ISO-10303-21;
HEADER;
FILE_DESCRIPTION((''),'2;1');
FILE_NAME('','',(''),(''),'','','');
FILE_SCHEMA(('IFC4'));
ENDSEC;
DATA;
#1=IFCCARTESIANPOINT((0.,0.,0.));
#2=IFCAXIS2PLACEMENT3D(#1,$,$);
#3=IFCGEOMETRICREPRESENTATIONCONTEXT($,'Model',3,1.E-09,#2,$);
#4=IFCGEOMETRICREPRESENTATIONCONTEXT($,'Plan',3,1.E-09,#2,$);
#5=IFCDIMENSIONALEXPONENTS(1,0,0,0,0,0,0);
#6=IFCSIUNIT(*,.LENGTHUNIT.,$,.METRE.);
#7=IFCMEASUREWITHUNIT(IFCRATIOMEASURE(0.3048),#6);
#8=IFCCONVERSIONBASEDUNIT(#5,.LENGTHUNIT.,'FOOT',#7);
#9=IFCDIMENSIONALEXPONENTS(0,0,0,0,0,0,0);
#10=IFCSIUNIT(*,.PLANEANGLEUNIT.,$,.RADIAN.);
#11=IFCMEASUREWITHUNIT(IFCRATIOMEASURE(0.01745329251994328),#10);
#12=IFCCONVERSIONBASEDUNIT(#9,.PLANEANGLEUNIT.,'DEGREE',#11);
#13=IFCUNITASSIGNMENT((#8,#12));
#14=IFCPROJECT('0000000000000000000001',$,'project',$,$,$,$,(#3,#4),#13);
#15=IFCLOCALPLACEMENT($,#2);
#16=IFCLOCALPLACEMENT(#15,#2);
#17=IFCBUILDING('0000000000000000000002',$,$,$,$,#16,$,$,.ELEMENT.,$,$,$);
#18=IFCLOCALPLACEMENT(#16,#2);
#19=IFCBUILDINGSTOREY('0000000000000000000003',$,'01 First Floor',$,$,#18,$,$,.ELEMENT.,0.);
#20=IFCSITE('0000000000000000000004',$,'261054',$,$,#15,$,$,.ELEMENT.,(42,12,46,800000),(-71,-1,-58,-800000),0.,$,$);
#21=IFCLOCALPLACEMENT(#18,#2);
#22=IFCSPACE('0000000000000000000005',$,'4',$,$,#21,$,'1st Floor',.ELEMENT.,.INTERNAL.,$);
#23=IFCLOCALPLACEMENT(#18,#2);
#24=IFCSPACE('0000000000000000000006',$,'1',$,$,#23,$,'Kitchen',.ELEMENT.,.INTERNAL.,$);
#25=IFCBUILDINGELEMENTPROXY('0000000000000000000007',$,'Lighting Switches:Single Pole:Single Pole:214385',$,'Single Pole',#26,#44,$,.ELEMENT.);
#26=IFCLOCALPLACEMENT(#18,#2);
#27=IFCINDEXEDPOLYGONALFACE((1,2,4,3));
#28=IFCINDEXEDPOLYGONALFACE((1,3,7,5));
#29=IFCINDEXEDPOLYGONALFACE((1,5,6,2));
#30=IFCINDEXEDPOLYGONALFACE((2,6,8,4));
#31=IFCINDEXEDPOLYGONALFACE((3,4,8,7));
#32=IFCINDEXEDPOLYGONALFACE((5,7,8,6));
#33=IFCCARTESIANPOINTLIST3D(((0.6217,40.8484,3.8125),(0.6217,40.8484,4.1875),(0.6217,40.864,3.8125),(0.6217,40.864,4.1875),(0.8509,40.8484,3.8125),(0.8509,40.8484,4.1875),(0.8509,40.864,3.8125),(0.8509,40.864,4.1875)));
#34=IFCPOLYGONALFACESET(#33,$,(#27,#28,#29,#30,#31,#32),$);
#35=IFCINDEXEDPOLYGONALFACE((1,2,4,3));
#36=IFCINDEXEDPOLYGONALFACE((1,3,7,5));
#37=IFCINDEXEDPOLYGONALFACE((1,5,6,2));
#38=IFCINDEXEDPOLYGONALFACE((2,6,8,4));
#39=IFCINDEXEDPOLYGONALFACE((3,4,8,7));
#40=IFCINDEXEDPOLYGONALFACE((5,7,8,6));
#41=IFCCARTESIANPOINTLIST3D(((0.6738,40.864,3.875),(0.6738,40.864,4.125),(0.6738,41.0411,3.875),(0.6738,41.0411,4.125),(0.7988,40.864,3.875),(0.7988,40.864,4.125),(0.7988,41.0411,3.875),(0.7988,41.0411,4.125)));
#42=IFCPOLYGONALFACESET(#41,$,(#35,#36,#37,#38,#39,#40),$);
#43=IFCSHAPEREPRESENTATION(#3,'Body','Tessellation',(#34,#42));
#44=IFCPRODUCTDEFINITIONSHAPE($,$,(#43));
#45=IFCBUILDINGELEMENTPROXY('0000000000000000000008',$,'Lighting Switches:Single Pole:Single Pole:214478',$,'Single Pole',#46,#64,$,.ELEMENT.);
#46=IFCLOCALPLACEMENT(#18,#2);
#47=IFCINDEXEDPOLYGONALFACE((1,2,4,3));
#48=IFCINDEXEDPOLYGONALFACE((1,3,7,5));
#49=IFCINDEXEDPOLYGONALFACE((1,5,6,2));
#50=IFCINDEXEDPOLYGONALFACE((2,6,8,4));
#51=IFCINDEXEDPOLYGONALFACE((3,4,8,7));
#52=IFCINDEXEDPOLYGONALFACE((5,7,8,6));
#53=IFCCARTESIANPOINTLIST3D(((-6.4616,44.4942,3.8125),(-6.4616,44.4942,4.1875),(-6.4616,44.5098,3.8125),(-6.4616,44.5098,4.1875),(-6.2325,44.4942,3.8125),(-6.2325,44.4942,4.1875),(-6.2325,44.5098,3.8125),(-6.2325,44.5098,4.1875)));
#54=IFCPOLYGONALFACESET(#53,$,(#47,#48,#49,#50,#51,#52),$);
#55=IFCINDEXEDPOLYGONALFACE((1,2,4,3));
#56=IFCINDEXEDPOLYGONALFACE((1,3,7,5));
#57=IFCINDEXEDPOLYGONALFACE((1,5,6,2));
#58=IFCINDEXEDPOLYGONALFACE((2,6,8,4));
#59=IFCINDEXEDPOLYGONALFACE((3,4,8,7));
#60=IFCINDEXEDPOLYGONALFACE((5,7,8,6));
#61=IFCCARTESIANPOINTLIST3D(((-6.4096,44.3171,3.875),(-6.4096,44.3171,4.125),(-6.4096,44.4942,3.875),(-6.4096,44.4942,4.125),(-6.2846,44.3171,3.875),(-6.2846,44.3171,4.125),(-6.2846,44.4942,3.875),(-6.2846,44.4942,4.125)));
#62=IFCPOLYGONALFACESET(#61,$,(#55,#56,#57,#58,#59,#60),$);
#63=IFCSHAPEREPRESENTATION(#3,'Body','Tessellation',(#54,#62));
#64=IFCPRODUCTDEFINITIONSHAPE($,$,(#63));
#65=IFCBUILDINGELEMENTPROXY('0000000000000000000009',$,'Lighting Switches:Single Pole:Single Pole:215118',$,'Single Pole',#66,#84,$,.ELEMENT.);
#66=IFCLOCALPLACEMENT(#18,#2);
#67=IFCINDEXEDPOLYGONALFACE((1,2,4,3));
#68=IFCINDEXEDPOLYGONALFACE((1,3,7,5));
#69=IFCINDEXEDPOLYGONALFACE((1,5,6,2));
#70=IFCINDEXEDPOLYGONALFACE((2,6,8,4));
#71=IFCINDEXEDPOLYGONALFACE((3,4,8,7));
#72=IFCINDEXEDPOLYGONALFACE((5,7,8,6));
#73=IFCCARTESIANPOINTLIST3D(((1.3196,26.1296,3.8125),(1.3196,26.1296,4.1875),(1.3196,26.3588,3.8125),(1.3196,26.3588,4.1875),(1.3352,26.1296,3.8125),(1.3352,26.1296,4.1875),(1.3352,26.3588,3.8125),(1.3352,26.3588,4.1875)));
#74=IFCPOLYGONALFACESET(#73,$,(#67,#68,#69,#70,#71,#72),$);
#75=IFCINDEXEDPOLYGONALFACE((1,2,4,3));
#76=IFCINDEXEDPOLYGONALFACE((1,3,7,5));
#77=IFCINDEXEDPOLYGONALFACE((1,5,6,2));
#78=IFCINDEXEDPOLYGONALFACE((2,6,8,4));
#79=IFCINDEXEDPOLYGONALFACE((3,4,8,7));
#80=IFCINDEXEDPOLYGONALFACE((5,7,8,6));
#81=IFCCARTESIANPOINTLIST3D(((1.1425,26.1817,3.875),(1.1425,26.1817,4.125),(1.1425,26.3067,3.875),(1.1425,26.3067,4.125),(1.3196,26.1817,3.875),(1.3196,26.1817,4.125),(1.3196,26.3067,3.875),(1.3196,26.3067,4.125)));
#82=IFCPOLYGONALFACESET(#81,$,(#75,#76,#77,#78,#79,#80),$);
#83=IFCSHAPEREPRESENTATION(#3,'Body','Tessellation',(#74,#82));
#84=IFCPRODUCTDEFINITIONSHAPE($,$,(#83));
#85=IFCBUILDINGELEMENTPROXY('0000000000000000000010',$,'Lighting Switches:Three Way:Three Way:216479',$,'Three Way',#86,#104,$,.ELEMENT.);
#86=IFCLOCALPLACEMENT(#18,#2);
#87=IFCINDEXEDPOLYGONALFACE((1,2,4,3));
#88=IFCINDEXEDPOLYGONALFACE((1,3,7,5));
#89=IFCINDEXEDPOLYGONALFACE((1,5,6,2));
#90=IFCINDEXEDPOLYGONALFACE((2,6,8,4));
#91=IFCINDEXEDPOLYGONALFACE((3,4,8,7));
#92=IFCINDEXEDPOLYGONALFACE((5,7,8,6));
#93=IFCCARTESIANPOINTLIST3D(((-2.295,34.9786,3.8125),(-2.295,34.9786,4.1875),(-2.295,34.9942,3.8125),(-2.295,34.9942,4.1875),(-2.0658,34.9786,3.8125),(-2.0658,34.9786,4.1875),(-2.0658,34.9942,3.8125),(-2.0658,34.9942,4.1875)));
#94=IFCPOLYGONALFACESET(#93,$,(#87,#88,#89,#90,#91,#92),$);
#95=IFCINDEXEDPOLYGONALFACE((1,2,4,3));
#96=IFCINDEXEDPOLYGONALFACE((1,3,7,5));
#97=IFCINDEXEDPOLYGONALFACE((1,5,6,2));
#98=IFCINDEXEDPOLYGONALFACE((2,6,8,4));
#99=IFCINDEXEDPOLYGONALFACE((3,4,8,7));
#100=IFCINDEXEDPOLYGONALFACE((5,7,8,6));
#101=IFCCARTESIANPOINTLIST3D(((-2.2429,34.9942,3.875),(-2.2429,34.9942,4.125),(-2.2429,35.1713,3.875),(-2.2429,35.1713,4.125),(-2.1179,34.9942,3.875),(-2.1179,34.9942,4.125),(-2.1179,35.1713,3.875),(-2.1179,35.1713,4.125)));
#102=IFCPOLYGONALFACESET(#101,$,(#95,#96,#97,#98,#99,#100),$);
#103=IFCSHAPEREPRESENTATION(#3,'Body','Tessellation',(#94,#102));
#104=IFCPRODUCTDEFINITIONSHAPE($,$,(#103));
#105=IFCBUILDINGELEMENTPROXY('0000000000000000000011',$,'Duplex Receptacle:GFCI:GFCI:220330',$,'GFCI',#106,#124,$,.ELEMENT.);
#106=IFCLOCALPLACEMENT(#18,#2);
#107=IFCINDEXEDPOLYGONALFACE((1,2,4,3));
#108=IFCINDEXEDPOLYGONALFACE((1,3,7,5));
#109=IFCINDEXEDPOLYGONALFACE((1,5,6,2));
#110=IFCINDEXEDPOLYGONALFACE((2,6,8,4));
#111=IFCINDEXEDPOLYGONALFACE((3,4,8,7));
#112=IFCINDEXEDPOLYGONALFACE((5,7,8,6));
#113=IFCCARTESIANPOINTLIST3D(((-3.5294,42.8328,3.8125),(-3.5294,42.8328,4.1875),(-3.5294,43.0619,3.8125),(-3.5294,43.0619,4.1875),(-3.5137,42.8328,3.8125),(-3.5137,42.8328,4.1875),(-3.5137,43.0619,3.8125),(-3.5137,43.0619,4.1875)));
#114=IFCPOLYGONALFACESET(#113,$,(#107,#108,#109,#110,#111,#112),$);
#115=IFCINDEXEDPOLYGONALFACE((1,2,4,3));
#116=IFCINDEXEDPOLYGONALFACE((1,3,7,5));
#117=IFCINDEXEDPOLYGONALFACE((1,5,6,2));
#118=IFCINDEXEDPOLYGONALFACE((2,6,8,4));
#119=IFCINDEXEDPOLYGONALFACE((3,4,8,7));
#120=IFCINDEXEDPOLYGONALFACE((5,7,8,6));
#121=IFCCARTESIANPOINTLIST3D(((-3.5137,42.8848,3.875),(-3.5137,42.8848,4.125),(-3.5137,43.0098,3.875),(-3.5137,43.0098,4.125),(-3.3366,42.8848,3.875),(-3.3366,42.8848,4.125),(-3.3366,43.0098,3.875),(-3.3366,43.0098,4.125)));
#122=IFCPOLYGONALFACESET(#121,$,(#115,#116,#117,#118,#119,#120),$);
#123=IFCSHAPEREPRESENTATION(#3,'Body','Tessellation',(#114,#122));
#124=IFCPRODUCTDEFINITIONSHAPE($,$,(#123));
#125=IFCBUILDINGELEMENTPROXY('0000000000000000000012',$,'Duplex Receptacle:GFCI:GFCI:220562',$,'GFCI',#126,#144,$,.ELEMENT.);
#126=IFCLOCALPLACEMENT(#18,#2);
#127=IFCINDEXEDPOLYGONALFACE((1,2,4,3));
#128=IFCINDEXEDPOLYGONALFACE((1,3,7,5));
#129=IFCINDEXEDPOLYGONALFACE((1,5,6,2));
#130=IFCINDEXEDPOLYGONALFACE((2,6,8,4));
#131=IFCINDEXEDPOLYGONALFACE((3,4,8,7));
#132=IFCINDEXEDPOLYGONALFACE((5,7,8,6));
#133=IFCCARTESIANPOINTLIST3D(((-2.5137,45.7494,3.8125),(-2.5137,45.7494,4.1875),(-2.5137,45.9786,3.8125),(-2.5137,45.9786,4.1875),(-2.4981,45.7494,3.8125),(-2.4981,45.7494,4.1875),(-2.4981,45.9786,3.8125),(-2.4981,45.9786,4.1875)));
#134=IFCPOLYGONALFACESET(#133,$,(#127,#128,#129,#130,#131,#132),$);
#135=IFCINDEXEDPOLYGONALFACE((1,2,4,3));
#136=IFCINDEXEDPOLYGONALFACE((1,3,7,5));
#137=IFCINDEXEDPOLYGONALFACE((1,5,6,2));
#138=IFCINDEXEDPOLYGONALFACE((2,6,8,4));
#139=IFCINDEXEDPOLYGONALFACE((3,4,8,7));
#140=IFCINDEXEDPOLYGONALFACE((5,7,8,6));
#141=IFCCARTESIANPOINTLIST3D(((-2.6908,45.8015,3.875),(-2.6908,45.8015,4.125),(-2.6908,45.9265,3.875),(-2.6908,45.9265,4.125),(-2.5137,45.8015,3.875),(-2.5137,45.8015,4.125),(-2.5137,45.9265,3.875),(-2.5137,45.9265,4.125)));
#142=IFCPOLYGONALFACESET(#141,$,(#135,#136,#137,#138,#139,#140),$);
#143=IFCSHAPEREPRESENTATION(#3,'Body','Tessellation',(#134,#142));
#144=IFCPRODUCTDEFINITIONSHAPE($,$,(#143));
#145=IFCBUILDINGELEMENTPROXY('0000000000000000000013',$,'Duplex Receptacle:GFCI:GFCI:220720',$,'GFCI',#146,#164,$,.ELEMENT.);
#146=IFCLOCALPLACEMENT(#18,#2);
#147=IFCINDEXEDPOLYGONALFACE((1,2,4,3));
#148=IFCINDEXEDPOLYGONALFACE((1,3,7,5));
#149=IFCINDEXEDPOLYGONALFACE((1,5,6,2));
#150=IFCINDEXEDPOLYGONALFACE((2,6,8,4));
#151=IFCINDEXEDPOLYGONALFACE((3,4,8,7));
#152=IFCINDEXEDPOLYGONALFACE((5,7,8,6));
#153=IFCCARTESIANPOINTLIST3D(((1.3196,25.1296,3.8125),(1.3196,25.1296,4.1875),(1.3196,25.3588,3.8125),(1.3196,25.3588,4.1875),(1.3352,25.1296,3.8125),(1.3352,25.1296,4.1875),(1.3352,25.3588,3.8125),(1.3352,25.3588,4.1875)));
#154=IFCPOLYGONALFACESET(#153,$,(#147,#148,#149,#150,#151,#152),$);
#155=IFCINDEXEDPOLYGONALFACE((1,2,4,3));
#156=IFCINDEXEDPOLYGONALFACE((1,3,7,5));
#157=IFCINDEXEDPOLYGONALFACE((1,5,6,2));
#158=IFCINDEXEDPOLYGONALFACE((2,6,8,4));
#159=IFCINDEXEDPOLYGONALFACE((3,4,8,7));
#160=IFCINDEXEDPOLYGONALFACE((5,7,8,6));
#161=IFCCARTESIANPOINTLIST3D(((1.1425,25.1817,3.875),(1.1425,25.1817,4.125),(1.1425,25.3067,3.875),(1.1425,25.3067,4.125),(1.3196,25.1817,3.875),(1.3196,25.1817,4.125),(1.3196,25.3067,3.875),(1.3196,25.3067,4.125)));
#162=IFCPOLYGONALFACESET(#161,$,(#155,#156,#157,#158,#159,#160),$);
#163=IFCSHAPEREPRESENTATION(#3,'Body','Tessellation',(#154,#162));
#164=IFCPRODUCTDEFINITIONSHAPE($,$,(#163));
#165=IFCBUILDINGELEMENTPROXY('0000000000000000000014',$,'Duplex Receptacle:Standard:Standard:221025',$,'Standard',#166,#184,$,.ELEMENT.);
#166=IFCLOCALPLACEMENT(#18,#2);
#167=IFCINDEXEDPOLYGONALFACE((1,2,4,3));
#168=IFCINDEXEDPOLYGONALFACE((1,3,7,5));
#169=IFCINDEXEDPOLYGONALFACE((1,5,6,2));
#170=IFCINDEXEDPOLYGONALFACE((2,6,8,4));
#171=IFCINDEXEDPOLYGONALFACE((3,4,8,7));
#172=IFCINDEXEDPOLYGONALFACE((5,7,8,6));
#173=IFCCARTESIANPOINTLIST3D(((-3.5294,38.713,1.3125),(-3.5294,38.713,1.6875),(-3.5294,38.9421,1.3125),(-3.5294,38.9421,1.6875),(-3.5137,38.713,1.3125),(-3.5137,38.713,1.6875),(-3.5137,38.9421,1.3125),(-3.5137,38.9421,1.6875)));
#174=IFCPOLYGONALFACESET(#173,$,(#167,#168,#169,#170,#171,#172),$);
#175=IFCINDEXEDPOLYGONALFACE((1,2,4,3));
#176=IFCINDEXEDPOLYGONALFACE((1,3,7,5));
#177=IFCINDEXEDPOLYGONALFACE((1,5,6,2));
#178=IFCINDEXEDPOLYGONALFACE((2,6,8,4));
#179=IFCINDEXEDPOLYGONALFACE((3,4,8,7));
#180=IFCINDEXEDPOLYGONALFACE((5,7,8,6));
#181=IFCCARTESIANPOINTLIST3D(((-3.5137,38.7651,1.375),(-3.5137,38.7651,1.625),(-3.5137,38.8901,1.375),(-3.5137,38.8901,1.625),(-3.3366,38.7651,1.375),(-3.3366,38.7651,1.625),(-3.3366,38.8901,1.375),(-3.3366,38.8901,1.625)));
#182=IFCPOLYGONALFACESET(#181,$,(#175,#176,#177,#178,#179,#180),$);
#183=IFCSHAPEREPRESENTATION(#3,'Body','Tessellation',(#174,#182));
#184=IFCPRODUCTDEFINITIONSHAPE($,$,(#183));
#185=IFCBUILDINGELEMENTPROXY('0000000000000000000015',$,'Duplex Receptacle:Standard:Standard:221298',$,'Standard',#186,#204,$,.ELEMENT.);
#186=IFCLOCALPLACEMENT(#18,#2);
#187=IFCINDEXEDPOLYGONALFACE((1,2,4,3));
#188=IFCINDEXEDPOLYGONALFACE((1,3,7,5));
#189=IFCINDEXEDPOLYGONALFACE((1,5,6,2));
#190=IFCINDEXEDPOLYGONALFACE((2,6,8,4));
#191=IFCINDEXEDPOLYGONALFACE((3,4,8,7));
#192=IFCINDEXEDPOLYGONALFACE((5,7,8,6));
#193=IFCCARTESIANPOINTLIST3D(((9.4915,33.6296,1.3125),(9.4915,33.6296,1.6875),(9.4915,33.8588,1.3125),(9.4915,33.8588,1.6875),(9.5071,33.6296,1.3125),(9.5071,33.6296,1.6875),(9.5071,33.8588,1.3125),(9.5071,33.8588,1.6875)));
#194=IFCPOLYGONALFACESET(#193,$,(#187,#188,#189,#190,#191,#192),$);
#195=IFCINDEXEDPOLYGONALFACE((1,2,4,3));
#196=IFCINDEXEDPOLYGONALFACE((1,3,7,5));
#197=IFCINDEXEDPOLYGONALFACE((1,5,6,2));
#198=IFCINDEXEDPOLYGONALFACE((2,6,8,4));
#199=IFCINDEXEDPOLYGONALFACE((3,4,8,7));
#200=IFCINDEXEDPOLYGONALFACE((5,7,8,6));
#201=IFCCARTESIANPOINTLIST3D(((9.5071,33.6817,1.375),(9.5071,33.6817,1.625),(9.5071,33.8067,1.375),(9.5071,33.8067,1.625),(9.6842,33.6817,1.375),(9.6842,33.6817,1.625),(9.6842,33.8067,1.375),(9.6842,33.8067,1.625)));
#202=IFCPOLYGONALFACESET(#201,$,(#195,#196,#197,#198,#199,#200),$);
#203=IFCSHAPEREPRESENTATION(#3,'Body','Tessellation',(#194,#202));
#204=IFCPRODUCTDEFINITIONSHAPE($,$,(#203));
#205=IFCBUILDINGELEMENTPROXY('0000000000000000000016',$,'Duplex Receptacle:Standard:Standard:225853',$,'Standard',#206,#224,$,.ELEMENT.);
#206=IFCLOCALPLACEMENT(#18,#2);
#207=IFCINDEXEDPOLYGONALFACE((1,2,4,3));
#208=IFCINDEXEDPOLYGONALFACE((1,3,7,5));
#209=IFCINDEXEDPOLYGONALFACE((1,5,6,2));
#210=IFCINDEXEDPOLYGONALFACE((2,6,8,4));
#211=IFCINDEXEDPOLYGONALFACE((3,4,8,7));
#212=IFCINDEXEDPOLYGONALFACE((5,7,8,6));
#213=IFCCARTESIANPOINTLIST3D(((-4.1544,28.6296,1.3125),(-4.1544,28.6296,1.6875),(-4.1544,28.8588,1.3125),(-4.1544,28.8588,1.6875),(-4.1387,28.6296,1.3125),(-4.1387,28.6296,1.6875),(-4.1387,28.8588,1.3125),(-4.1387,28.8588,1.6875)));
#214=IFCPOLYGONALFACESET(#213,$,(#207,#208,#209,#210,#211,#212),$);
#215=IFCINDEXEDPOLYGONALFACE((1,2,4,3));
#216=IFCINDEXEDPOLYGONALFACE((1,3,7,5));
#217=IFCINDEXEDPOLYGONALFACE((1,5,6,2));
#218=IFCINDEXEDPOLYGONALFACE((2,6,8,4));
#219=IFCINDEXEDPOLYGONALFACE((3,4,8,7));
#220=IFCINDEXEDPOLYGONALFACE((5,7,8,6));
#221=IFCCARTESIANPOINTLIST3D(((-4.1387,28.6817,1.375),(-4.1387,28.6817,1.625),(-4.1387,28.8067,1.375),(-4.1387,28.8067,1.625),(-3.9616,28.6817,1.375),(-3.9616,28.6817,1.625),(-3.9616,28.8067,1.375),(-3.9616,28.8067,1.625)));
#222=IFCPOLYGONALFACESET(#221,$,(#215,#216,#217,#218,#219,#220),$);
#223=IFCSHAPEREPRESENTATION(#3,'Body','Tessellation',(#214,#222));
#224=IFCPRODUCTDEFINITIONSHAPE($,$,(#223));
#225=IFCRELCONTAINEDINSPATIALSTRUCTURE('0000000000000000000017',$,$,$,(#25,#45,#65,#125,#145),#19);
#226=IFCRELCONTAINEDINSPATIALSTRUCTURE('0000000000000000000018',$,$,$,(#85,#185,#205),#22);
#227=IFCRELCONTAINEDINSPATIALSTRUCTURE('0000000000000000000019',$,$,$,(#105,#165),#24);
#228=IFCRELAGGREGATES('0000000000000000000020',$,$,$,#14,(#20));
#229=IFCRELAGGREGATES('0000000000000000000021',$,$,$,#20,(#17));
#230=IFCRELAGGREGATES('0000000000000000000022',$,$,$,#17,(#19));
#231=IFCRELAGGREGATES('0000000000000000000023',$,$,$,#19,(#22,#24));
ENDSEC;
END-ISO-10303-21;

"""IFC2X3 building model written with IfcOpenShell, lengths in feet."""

from ifc_helpers import new_model, entity, si_unit, converted_unit, frame, origin, origin_2d_with_axis, place, context, project, spatial, rectangle, extrude, source, transform, mapped, element, save


model = new_model("IFC2X3")

# Units and contexts
model_context = context("Model", 3, precision=1e-09, world=origin())
plan_context = context("Plan", 3, precision=1e-09, world=origin())
ifc_project = project(units=[converted_unit("LENGTHUNIT", "FOOT", entity("IfcRatioMeasure", 0.3048), si_unit("LENGTHUNIT", "METRE"), dimensions=[1, 0, 0, 0, 0, 0, 0]), converted_unit("PLANEANGLEUNIT", "DEGREE", entity("IfcRatioMeasure", 0.01745329251994328), si_unit("PLANEANGLEUNIT", "RADIAN"), dimensions=[0, 0, 0, 0, 0, 0, 0])], contexts=[model_context, plan_context])

# Site, building, storey
site_placement = place(None, origin())
site = spatial("IfcSite", under=ifc_project, at=site_placement, Name="261054", CompositionType="ELEMENT", RefLatitude=(42, 12, 46, 800000), RefLongitude=(-71, -1, -58, -800000), RefElevation=0.0)
building_placement = place(site_placement, origin())
building = spatial("IfcBuilding", under=site, at=building_placement, CompositionType="ELEMENT")
storey_placement = place(building_placement, origin())
storey = spatial("IfcBuildingStorey", under=building, at=storey_placement, Name="01 First Floor", CompositionType="ELEMENT", Elevation=0.0)

# Building element proxies
shared_shape_1 = source(origin(), model_context, "Body", "SweptSolid", [
    extrude(rectangle(XDim=0.2292, YDim=0.375, at=origin_2d_with_axis()), frame((0.0, 0.0, 0.0), z_axis=(0.0, 0.0, 1.0), x_axis=(-1.0, 0.0, 0.0)), (0.0, 0.0, 1.0), 0.0156),
    extrude(rectangle(XDim=0.125, YDim=0.25, at=origin_2d_with_axis()), frame((0.0, 0.0, -0.1771), z_axis=(0.0, 0.0, 1.0), x_axis=(-1.0, 0.0, 0.0)), (0.0, 0.0, 1.0), 0.1771),
])
for number, where, z_axis, x_axis, name in (
    (1, (0.7363, 40.864, 4.0), (0.0, -1.0, 0.0), (1.0, 0.0, 0.0), "Lighting Switches:Single Pole:Single Pole:214385"),
    (2, (-6.3471, 44.4942, 4.0), (0.0, 1.0, 0.0), (-1.0, 0.0, 0.0), "Lighting Switches:Single Pole:Single Pole:214478"),
    (3, (1.3196, 26.2442, 4.0), (1.0, 0.0, 0.0), (0.0, 1.0, 0.0), "Lighting Switches:Single Pole:Single Pole:215118"),
):
    element("IfcBuildingElementProxy", number, at=place(storey_placement, frame(where, z_axis=z_axis, x_axis=x_axis)), inside=storey, Name=name, ObjectType="Single Pole", CompositionType="ELEMENT", context=model_context, shape_type="MappedRepresentation", body=[
        mapped(shared_shape_1, transform((0.0, 0.0, 0.0), scale=1.0)),
    ])

# Shared definitions
space_1_placement = place(storey_placement, origin())
space_1 = spatial("IfcSpace", under=storey, at=space_1_placement, Name="4", LongName="1st Floor", CompositionType="ELEMENT", InteriorOrExteriorSpace="INTERNAL")

# Building element proxy
shared_shape_2 = source(origin(), model_context, "Body", "SweptSolid", [
    extrude(rectangle(XDim=0.2292, YDim=0.375, at=origin_2d_with_axis()), frame((0.0, 0.0, 0.0), z_axis=(0.0, 0.0, 1.0), x_axis=(-1.0, 0.0, 0.0)), (0.0, 0.0, 1.0), 0.0156),
    extrude(rectangle(XDim=0.125, YDim=0.25, at=origin_2d_with_axis()), frame((0.0, 0.0, -0.1771), z_axis=(0.0, 0.0, 1.0), x_axis=(-1.0, 0.0, 0.0)), (0.0, 0.0, 1.0), 0.1771),
])
proxy_1_placement = place(space_1_placement, frame((-2.1804, 34.9942, 4.0), z_axis=(0.0, -1.0, 0.0), x_axis=(1.0, 0.0, 0.0)))
element("IfcBuildingElementProxy", 4, at=proxy_1_placement, inside=space_1, Name="Lighting Switches:Three Way:Three Way:216479", ObjectType="Three Way", CompositionType="ELEMENT", context=model_context, shape_type="MappedRepresentation", body=[
    mapped(shared_shape_2, transform((0.0, 0.0, 0.0), scale=1.0)),
])

# Shared definitions
space_2_placement = place(storey_placement, origin())
space_2 = spatial("IfcSpace", under=storey, at=space_2_placement, Name="1", LongName="Kitchen", CompositionType="ELEMENT", InteriorOrExteriorSpace="INTERNAL")

# Building element proxies
shared_shape_3 = source(origin(), model_context, "Body", "SweptSolid", [
    extrude(rectangle(XDim=0.2292, YDim=0.375, at=origin_2d_with_axis()), frame((0.0, 0.0, 0.0), z_axis=(0.0, 0.0, 1.0), x_axis=(-1.0, 0.0, 0.0)), (0.0, 0.0, 1.0), 0.0156),
    extrude(rectangle(XDim=0.125, YDim=0.25, at=origin_2d_with_axis()), frame((0.0, 0.0, -0.1771), z_axis=(0.0, 0.0, 1.0), x_axis=(-1.0, 0.0, 0.0)), (0.0, 0.0, 1.0), 0.1771),
])
proxy_2_placement = place(space_2_placement, frame((-3.5137, 42.9473, 4.0), z_axis=(-1.0, 0.0, 0.0), x_axis=(0.0, -1.0, 0.0)))
element("IfcBuildingElementProxy", 5, at=proxy_2_placement, inside=space_2, Name="Duplex Receptacle:GFCI:GFCI:220330", ObjectType="GFCI", CompositionType="ELEMENT", context=model_context, shape_type="MappedRepresentation", body=[
    mapped(shared_shape_3, transform((0.0, 0.0, 0.0), scale=1.0)),
])
for number, where, z_axis, x_axis, name in (
    (6, (-2.5137, 45.864, 4.0), (1.0, 0.0, 0.0), (0.0, 1.0, 0.0), "Duplex Receptacle:GFCI:GFCI:220562"),
    (7, (1.3196, 25.2442, 4.0), (1.0, 0.0, 0.0), (0.0, 1.0, 0.0), "Duplex Receptacle:GFCI:GFCI:220720"),
):
    element("IfcBuildingElementProxy", number, at=place(storey_placement, frame(where, z_axis=z_axis, x_axis=x_axis)), inside=storey, Name=name, ObjectType="GFCI", CompositionType="ELEMENT", context=model_context, shape_type="MappedRepresentation", body=[
        mapped(shared_shape_3, transform((0.0, 0.0, 0.0), scale=1.0)),
    ])
shared_shape_4 = source(origin(), model_context, "Body", "SweptSolid", [
    extrude(rectangle(XDim=0.2292, YDim=0.375, at=origin_2d_with_axis()), frame((0.0, 0.0, 0.0), z_axis=(0.0, 0.0, 1.0), x_axis=(-1.0, 0.0, 0.0)), (0.0, 0.0, 1.0), 0.0156),
    extrude(rectangle(XDim=0.125, YDim=0.25, at=origin_2d_with_axis()), frame((0.0, 0.0, -0.1771), z_axis=(0.0, 0.0, 1.0), x_axis=(-1.0, 0.0, 0.0)), (0.0, 0.0, 1.0), 0.1771),
])
proxy_3_placement = place(space_2_placement, frame((-3.5137, 38.8276, 1.5), z_axis=(-1.0, 0.0, 0.0), x_axis=(0.0, -1.0, 0.0)))
element("IfcBuildingElementProxy", 8, at=proxy_3_placement, inside=space_2, Name="Duplex Receptacle:Standard:Standard:221025", ObjectType="Standard", CompositionType="ELEMENT", context=model_context, shape_type="MappedRepresentation", body=[
    mapped(shared_shape_4, transform((0.0, 0.0, 0.0), scale=1.0)),
])
for number, where, z_axis, x_axis, name in (
    (9, (9.5071, 33.7442, 1.5), (-1.0, 0.0, 0.0), (0.0, -1.0, 0.0), "Duplex Receptacle:Standard:Standard:221298"),
    (10, (-4.1387, 28.7442, 1.5), (-1.0, 0.0, 0.0), (0.0, -1.0, 0.0), "Duplex Receptacle:Standard:Standard:225853"),
):
    element("IfcBuildingElementProxy", number, at=place(space_1_placement, frame(where, z_axis=z_axis, x_axis=x_axis)), inside=space_1, Name=name, ObjectType="Standard", CompositionType="ELEMENT", context=model_context, shape_type="MappedRepresentation", body=[
        mapped(shared_shape_4, transform((0.0, 0.0, 0.0), scale=1.0)),
    ])

save(model, "model.ifc")
